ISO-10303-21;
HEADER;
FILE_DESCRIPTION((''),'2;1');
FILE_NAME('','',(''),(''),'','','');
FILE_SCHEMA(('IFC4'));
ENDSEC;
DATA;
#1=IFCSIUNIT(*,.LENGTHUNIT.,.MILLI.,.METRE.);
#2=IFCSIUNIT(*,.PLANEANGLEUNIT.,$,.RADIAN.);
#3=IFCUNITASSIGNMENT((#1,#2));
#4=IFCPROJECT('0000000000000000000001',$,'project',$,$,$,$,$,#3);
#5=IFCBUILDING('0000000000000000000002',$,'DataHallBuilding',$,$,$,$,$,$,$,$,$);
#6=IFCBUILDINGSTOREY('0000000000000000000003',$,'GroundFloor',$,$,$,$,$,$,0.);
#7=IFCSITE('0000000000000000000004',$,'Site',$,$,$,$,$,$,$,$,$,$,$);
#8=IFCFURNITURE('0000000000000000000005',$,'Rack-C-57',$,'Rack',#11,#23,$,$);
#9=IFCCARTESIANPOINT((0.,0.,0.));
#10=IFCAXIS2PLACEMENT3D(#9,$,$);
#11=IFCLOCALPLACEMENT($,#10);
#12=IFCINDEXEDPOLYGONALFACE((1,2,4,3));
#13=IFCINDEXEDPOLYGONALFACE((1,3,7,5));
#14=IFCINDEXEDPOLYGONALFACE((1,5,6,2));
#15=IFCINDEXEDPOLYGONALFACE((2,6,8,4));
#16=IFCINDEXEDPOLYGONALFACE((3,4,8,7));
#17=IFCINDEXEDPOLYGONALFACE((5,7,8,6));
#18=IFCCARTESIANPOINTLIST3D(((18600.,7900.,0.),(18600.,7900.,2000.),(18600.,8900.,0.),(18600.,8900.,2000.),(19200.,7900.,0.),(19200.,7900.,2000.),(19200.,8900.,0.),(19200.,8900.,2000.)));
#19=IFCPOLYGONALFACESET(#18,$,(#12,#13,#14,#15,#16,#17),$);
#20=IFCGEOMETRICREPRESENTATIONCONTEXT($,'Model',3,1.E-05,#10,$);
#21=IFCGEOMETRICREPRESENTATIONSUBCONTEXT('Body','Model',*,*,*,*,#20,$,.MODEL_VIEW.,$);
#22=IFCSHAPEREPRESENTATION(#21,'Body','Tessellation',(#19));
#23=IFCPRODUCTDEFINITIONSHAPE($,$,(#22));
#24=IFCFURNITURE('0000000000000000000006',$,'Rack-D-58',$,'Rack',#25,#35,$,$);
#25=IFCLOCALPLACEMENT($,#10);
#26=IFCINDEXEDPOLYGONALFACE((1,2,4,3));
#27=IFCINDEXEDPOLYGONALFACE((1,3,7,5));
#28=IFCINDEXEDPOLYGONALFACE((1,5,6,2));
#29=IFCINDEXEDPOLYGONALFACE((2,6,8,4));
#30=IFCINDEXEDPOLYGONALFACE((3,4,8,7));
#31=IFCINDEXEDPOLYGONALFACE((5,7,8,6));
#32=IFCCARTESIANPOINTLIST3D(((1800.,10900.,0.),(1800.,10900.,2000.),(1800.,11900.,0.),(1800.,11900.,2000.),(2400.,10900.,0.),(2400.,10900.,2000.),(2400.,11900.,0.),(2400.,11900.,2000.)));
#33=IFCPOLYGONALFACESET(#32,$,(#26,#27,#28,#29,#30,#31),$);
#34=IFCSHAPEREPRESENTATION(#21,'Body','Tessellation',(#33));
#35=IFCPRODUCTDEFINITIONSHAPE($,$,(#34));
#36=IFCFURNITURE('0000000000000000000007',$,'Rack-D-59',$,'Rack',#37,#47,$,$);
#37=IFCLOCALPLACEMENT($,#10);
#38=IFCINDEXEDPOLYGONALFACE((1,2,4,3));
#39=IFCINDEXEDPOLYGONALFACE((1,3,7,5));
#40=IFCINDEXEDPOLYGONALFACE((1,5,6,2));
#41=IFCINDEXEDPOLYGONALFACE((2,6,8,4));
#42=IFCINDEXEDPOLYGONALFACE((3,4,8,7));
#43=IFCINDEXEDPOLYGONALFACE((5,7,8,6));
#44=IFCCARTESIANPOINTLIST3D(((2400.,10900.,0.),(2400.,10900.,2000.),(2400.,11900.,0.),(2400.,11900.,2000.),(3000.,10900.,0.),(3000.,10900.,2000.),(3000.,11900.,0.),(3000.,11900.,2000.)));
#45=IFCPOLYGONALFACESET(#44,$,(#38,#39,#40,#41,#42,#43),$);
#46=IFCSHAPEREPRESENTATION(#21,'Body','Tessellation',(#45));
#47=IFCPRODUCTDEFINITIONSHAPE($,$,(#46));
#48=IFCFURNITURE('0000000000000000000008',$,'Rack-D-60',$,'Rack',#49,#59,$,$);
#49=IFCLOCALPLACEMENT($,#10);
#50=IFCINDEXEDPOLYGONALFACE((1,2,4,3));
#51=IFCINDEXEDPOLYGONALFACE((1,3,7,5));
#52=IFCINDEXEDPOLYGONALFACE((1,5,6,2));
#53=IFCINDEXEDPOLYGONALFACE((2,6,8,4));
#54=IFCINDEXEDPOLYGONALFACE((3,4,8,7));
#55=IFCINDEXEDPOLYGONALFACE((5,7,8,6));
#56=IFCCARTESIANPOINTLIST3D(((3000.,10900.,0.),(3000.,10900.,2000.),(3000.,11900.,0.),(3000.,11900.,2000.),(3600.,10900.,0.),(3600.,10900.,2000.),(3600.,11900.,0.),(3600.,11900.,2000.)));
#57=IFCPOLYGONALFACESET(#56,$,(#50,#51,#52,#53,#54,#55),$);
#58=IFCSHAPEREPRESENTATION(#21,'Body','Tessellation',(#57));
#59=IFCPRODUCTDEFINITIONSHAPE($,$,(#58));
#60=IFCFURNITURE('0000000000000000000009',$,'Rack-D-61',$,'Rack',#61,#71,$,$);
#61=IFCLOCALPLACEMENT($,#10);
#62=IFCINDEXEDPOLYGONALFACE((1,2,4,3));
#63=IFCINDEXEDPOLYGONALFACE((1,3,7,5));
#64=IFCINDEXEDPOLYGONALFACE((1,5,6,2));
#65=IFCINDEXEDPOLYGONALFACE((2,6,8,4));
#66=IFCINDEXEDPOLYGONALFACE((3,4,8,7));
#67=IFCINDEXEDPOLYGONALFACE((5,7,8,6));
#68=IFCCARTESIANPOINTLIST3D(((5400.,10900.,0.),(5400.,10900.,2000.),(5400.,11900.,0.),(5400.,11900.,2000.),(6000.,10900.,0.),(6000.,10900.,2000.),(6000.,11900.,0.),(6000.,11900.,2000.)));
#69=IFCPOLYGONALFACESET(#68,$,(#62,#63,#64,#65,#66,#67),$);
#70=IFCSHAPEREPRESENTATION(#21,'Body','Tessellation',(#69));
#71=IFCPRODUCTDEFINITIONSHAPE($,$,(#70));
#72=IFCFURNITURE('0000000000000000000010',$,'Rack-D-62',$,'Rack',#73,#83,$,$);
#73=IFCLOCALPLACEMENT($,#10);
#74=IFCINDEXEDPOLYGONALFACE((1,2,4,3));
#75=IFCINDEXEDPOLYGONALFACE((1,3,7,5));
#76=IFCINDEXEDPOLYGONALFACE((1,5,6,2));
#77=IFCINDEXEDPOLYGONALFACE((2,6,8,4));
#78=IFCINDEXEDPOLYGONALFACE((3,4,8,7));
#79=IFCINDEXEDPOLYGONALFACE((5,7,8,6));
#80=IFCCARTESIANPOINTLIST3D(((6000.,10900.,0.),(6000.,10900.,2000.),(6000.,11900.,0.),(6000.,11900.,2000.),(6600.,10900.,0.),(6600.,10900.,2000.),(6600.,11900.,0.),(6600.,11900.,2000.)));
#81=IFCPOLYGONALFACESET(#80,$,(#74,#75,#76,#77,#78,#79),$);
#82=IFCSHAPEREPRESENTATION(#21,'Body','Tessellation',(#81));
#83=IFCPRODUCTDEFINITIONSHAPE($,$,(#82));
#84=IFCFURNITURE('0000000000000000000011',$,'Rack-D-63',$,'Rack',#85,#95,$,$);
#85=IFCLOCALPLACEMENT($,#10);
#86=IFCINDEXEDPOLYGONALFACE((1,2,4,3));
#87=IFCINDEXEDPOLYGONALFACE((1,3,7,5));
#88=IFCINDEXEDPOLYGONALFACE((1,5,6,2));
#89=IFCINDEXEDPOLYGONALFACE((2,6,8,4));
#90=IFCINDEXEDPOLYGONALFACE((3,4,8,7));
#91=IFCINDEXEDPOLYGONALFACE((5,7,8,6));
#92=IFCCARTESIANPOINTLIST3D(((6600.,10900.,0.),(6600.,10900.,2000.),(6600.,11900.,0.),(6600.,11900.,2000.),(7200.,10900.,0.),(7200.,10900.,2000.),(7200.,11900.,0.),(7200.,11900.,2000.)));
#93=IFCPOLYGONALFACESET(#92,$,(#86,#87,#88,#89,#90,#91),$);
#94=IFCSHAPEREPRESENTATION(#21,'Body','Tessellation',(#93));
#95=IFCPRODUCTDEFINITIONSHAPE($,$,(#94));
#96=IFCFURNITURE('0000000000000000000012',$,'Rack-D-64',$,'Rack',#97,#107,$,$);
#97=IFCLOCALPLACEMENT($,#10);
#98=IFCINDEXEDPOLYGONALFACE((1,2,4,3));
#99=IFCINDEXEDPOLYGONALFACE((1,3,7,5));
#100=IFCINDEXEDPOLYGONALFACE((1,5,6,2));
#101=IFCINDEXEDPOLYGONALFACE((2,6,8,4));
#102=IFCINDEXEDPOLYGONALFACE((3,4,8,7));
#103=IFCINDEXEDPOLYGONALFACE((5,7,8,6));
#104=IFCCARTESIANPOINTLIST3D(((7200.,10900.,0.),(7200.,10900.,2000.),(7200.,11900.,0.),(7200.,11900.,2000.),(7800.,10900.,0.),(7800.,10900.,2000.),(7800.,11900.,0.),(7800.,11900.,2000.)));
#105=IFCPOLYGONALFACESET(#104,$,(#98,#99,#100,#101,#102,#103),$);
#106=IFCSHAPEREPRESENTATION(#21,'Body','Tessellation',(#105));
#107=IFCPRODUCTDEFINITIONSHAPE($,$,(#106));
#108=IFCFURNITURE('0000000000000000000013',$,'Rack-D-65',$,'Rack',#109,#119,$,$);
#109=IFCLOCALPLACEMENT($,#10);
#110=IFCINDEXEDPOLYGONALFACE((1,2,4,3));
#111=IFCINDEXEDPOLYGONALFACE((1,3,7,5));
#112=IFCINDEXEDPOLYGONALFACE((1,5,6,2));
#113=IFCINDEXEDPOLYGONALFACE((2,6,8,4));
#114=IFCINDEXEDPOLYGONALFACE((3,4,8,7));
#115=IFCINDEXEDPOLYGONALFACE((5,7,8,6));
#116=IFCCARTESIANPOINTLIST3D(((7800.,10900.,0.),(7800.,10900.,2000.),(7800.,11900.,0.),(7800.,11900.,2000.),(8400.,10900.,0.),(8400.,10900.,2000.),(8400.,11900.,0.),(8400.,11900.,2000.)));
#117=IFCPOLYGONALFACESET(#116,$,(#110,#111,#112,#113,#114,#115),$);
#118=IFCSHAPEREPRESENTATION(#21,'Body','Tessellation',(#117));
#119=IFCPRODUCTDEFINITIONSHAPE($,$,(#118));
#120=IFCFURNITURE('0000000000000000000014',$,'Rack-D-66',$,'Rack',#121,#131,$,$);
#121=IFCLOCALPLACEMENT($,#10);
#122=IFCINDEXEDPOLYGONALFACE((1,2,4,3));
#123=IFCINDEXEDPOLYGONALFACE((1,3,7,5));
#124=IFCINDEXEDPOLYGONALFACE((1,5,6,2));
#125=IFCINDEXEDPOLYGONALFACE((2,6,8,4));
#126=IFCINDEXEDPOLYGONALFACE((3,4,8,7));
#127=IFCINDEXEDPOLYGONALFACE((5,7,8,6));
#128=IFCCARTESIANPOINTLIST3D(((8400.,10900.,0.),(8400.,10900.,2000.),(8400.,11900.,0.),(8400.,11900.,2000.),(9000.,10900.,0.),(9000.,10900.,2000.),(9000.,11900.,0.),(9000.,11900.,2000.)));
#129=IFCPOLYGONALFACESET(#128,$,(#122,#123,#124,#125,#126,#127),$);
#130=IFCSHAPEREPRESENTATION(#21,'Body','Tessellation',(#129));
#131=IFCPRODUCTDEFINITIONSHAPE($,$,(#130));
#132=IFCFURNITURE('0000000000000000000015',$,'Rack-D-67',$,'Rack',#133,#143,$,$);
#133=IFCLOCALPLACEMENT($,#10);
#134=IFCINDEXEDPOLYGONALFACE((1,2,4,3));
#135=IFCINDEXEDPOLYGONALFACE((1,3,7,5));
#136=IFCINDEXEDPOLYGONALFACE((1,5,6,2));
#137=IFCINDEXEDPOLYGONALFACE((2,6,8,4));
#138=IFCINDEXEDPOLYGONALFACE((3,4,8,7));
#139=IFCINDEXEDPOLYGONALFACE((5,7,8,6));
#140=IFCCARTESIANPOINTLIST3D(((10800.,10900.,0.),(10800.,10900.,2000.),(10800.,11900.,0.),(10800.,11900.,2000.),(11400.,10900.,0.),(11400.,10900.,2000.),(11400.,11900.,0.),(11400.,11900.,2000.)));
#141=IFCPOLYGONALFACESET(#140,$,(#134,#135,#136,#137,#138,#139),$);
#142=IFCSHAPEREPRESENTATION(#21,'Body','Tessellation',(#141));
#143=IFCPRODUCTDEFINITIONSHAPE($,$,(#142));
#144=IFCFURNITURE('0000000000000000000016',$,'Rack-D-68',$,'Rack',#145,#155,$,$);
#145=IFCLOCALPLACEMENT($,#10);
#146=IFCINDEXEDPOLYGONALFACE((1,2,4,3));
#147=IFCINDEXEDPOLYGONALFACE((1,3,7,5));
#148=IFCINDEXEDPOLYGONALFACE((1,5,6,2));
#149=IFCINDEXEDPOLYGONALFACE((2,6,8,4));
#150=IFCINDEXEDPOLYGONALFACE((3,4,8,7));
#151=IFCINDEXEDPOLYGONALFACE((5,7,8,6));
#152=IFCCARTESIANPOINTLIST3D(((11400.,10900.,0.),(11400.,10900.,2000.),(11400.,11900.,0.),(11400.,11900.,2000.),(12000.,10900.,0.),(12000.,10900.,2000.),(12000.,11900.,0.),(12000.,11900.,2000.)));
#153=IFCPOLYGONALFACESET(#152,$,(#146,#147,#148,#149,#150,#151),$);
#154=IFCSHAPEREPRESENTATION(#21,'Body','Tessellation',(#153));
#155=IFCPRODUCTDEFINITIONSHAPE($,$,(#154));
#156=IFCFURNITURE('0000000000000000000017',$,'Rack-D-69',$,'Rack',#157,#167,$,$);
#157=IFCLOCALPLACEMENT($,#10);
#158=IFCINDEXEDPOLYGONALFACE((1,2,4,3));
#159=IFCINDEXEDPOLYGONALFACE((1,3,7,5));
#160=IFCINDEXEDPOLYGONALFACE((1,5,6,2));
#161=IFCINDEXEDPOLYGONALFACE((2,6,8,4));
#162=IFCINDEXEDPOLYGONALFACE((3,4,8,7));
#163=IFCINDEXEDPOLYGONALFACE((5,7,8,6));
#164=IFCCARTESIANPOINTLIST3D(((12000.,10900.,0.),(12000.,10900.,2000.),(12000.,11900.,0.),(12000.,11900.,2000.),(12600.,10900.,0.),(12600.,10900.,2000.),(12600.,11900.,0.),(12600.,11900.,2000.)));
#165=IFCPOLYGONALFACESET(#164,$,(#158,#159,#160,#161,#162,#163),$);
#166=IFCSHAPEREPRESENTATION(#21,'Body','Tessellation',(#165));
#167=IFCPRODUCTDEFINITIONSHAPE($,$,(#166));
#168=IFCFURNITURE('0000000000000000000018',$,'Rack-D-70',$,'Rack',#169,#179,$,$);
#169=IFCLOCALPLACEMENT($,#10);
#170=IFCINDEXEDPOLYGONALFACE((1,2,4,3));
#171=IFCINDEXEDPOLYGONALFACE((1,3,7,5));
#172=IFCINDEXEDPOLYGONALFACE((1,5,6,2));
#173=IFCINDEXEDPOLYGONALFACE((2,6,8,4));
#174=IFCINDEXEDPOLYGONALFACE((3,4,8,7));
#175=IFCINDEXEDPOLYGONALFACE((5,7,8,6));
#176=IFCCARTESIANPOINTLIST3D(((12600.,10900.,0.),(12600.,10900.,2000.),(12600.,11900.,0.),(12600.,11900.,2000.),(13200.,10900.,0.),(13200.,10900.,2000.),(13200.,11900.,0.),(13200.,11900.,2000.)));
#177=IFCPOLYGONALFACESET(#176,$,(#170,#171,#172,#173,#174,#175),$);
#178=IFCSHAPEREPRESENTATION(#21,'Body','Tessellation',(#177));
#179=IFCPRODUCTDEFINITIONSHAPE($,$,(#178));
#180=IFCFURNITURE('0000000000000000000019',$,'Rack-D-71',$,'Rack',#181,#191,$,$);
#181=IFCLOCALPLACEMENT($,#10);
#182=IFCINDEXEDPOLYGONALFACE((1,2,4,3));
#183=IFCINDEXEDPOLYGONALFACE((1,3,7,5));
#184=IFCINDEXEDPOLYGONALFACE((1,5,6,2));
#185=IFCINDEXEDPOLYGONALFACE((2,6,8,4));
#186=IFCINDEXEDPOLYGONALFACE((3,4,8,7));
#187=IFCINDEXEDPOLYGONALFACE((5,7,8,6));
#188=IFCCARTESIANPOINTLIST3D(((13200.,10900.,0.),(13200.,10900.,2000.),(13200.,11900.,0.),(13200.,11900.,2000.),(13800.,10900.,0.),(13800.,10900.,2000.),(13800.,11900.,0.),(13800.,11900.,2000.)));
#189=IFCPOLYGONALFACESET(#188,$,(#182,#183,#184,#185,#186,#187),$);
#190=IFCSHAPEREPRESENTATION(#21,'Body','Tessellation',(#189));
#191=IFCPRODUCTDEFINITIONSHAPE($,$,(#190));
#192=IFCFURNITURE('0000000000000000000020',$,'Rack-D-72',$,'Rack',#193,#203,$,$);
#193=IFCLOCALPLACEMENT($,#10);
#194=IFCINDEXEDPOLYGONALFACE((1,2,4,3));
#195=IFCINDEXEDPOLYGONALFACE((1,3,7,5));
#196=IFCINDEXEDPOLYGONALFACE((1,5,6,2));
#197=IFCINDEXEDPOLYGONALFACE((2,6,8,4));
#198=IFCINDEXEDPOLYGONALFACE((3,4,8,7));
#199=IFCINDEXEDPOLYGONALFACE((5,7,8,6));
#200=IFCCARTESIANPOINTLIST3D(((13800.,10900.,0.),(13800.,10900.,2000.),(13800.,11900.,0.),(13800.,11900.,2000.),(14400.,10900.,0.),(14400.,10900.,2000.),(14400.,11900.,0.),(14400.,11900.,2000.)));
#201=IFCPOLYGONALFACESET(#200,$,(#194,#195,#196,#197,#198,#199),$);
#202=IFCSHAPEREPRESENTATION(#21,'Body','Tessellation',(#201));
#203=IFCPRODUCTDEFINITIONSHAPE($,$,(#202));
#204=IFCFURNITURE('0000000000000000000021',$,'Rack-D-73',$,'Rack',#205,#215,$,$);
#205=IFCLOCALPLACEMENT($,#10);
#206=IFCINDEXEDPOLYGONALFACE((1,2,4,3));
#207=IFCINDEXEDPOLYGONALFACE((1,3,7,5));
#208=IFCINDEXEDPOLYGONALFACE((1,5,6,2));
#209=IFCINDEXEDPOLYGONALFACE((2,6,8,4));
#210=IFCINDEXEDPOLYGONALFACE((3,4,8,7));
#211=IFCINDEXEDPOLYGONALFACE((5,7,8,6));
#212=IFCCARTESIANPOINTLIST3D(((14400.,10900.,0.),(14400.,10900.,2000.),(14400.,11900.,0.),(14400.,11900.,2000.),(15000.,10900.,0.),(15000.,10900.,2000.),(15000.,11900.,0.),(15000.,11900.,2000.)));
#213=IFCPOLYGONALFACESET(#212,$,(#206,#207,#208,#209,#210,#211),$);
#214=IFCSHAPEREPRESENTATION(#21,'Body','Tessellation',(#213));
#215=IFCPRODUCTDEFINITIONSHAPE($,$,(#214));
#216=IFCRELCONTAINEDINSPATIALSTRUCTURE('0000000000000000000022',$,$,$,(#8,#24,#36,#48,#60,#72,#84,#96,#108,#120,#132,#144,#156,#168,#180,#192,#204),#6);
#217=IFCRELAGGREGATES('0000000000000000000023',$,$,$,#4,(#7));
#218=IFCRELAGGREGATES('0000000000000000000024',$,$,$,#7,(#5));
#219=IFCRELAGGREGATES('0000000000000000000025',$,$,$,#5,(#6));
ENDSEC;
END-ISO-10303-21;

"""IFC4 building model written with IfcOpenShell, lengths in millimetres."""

from ifc_helpers import new_model, si_unit, frame, origin, place, context, subcontext, project, spatial, rectangle, extrude, element, save


model = new_model("IFC4")

# Units and contexts
model_context = context("Model", 3, precision=1e-05, world=origin())
body_context = subcontext(model_context, "Body", "Model", "MODEL_VIEW")
ifc_project = project(units=[si_unit("LENGTHUNIT", "METRE", prefix="MILLI"), si_unit("PLANEANGLEUNIT", "RADIAN")])

# Site, building, storey
site = spatial("IfcSite", under=ifc_project, Name="Site")
building = spatial("IfcBuilding", under=site, Name="DataHallBuilding")
storey = spatial("IfcBuildingStorey", under=building, Name="GroundFloor", Elevation=0.0)

# Furniture
furniture_1_placement = place(None, origin())
element("IfcFurniture", 1, at=furniture_1_placement, inside=storey, Name="Rack-C-57", ObjectType="Rack", context=body_context, shape_type="SweptSolid", body=[
    extrude(rectangle(XDim=600.0, YDim=1000.0), frame((18900.0, 8400.0, 0.0), z_axis=(0.0, 0.0, 1.0), x_axis=(1.0, 0.0, 0.0)), (0.0, 0.0, 1.0), 2000.0),
])
furniture_2_placement = place(None, origin())
element("IfcFurniture", 2, at=furniture_2_placement, inside=storey, Name="Rack-D-58", ObjectType="Rack", context=body_context, shape_type="SweptSolid", body=[
    extrude(rectangle(XDim=600.0, YDim=1000.0), frame((2100.0, 11400.0, 0.0), z_axis=(0.0, 0.0, 1.0), x_axis=(1.0, 0.0, 0.0)), (0.0, 0.0, 1.0), 2000.0),
])
furniture_3_placement = place(None, origin())
element("IfcFurniture", 3, at=furniture_3_placement, inside=storey, Name="Rack-D-59", ObjectType="Rack", context=body_context, shape_type="SweptSolid", body=[
    extrude(rectangle(XDim=600.0, YDim=1000.0), frame((2700.0, 11400.0, 0.0), z_axis=(0.0, 0.0, 1.0), x_axis=(1.0, 0.0, 0.0)), (0.0, 0.0, 1.0), 2000.0),
])
furniture_4_placement = place(None, origin())
element("IfcFurniture", 4, at=furniture_4_placement, inside=storey, Name="Rack-D-60", ObjectType="Rack", context=body_context, shape_type="SweptSolid", body=[
    extrude(rectangle(XDim=600.0, YDim=1000.0), frame((3300.0, 11400.0, 0.0), z_axis=(0.0, 0.0, 1.0), x_axis=(1.0, 0.0, 0.0)), (0.0, 0.0, 1.0), 2000.0),
])
furniture_5_placement = place(None, origin())
element("IfcFurniture", 5, at=furniture_5_placement, inside=storey, Name="Rack-D-61", ObjectType="Rack", context=body_context, shape_type="SweptSolid", body=[
    extrude(rectangle(XDim=600.0, YDim=1000.0), frame((5700.0, 11400.0, 0.0), z_axis=(0.0, 0.0, 1.0), x_axis=(1.0, 0.0, 0.0)), (0.0, 0.0, 1.0), 2000.0),
])
furniture_6_placement = place(None, origin())
element("IfcFurniture", 6, at=furniture_6_placement, inside=storey, Name="Rack-D-62", ObjectType="Rack", context=body_context, shape_type="SweptSolid", body=[
    extrude(rectangle(XDim=600.0, YDim=1000.0), frame((6300.0, 11400.0, 0.0), z_axis=(0.0, 0.0, 1.0), x_axis=(1.0, 0.0, 0.0)), (0.0, 0.0, 1.0), 2000.0),
])
furniture_7_placement = place(None, origin())
element("IfcFurniture", 7, at=furniture_7_placement, inside=storey, Name="Rack-D-63", ObjectType="Rack", context=body_context, shape_type="SweptSolid", body=[
    extrude(rectangle(XDim=600.0, YDim=1000.0), frame((6900.0, 11400.0, 0.0), z_axis=(0.0, 0.0, 1.0), x_axis=(1.0, 0.0, 0.0)), (0.0, 0.0, 1.0), 2000.0),
])
furniture_8_placement = place(None, origin())
element("IfcFurniture", 8, at=furniture_8_placement, inside=storey, Name="Rack-D-64", ObjectType="Rack", context=body_context, shape_type="SweptSolid", body=[
    extrude(rectangle(XDim=600.0, YDim=1000.0), frame((7500.0, 11400.0, 0.0), z_axis=(0.0, 0.0, 1.0), x_axis=(1.0, 0.0, 0.0)), (0.0, 0.0, 1.0), 2000.0),
])
furniture_9_placement = place(None, origin())
element("IfcFurniture", 9, at=furniture_9_placement, inside=storey, Name="Rack-D-65", ObjectType="Rack", context=body_context, shape_type="SweptSolid", body=[
    extrude(rectangle(XDim=600.0, YDim=1000.0), frame((8100.0, 11400.0, 0.0), z_axis=(0.0, 0.0, 1.0), x_axis=(1.0, 0.0, 0.0)), (0.0, 0.0, 1.0), 2000.0),
])
furniture_10_placement = place(None, origin())
element("IfcFurniture", 10, at=furniture_10_placement, inside=storey, Name="Rack-D-66", ObjectType="Rack", context=body_context, shape_type="SweptSolid", body=[
    extrude(rectangle(XDim=600.0, YDim=1000.0), frame((8700.0, 11400.0, 0.0), z_axis=(0.0, 0.0, 1.0), x_axis=(1.0, 0.0, 0.0)), (0.0, 0.0, 1.0), 2000.0),
])
furniture_11_placement = place(None, origin())
element("IfcFurniture", 11, at=furniture_11_placement, inside=storey, Name="Rack-D-67", ObjectType="Rack", context=body_context, shape_type="SweptSolid", body=[
    extrude(rectangle(XDim=600.0, YDim=1000.0), frame((11100.0, 11400.0, 0.0), z_axis=(0.0, 0.0, 1.0), x_axis=(1.0, 0.0, 0.0)), (0.0, 0.0, 1.0), 2000.0),
])
furniture_12_placement = place(None, origin())
element("IfcFurniture", 12, at=furniture_12_placement, inside=storey, Name="Rack-D-68", ObjectType="Rack", context=body_context, shape_type="SweptSolid", body=[
    extrude(rectangle(XDim=600.0, YDim=1000.0), frame((11700.0, 11400.0, 0.0), z_axis=(0.0, 0.0, 1.0), x_axis=(1.0, 0.0, 0.0)), (0.0, 0.0, 1.0), 2000.0),
])
furniture_13_placement = place(None, origin())
element("IfcFurniture", 13, at=furniture_13_placement, inside=storey, Name="Rack-D-69", ObjectType="Rack", context=body_context, shape_type="SweptSolid", body=[
    extrude(rectangle(XDim=600.0, YDim=1000.0), frame((12300.0, 11400.0, 0.0), z_axis=(0.0, 0.0, 1.0), x_axis=(1.0, 0.0, 0.0)), (0.0, 0.0, 1.0), 2000.0),
])
furniture_14_placement = place(None, origin())
element("IfcFurniture", 14, at=furniture_14_placement, inside=storey, Name="Rack-D-70", ObjectType="Rack", context=body_context, shape_type="SweptSolid", body=[
    extrude(rectangle(XDim=600.0, YDim=1000.0), frame((12900.0, 11400.0, 0.0), z_axis=(0.0, 0.0, 1.0), x_axis=(1.0, 0.0, 0.0)), (0.0, 0.0, 1.0), 2000.0),
])
furniture_15_placement = place(None, origin())
element("IfcFurniture", 15, at=furniture_15_placement, inside=storey, Name="Rack-D-71", ObjectType="Rack", context=body_context, shape_type="SweptSolid", body=[
    extrude(rectangle(XDim=600.0, YDim=1000.0), frame((13500.0, 11400.0, 0.0), z_axis=(0.0, 0.0, 1.0), x_axis=(1.0, 0.0, 0.0)), (0.0, 0.0, 1.0), 2000.0),
])
furniture_16_placement = place(None, origin())
element("IfcFurniture", 16, at=furniture_16_placement, inside=storey, Name="Rack-D-72", ObjectType="Rack", context=body_context, shape_type="SweptSolid", body=[
    extrude(rectangle(XDim=600.0, YDim=1000.0), frame((14100.0, 11400.0, 0.0), z_axis=(0.0, 0.0, 1.0), x_axis=(1.0, 0.0, 0.0)), (0.0, 0.0, 1.0), 2000.0),
])
furniture_17_placement = place(None, origin())
element("IfcFurniture", 17, at=furniture_17_placement, inside=storey, Name="Rack-D-73", ObjectType="Rack", context=body_context, shape_type="SweptSolid", body=[
    extrude(rectangle(XDim=600.0, YDim=1000.0), frame((14700.0, 11400.0, 0.0), z_axis=(0.0, 0.0, 1.0), x_axis=(1.0, 0.0, 0.0)), (0.0, 0.0, 1.0), 2000.0),
])

save(model, "model.ifc")
